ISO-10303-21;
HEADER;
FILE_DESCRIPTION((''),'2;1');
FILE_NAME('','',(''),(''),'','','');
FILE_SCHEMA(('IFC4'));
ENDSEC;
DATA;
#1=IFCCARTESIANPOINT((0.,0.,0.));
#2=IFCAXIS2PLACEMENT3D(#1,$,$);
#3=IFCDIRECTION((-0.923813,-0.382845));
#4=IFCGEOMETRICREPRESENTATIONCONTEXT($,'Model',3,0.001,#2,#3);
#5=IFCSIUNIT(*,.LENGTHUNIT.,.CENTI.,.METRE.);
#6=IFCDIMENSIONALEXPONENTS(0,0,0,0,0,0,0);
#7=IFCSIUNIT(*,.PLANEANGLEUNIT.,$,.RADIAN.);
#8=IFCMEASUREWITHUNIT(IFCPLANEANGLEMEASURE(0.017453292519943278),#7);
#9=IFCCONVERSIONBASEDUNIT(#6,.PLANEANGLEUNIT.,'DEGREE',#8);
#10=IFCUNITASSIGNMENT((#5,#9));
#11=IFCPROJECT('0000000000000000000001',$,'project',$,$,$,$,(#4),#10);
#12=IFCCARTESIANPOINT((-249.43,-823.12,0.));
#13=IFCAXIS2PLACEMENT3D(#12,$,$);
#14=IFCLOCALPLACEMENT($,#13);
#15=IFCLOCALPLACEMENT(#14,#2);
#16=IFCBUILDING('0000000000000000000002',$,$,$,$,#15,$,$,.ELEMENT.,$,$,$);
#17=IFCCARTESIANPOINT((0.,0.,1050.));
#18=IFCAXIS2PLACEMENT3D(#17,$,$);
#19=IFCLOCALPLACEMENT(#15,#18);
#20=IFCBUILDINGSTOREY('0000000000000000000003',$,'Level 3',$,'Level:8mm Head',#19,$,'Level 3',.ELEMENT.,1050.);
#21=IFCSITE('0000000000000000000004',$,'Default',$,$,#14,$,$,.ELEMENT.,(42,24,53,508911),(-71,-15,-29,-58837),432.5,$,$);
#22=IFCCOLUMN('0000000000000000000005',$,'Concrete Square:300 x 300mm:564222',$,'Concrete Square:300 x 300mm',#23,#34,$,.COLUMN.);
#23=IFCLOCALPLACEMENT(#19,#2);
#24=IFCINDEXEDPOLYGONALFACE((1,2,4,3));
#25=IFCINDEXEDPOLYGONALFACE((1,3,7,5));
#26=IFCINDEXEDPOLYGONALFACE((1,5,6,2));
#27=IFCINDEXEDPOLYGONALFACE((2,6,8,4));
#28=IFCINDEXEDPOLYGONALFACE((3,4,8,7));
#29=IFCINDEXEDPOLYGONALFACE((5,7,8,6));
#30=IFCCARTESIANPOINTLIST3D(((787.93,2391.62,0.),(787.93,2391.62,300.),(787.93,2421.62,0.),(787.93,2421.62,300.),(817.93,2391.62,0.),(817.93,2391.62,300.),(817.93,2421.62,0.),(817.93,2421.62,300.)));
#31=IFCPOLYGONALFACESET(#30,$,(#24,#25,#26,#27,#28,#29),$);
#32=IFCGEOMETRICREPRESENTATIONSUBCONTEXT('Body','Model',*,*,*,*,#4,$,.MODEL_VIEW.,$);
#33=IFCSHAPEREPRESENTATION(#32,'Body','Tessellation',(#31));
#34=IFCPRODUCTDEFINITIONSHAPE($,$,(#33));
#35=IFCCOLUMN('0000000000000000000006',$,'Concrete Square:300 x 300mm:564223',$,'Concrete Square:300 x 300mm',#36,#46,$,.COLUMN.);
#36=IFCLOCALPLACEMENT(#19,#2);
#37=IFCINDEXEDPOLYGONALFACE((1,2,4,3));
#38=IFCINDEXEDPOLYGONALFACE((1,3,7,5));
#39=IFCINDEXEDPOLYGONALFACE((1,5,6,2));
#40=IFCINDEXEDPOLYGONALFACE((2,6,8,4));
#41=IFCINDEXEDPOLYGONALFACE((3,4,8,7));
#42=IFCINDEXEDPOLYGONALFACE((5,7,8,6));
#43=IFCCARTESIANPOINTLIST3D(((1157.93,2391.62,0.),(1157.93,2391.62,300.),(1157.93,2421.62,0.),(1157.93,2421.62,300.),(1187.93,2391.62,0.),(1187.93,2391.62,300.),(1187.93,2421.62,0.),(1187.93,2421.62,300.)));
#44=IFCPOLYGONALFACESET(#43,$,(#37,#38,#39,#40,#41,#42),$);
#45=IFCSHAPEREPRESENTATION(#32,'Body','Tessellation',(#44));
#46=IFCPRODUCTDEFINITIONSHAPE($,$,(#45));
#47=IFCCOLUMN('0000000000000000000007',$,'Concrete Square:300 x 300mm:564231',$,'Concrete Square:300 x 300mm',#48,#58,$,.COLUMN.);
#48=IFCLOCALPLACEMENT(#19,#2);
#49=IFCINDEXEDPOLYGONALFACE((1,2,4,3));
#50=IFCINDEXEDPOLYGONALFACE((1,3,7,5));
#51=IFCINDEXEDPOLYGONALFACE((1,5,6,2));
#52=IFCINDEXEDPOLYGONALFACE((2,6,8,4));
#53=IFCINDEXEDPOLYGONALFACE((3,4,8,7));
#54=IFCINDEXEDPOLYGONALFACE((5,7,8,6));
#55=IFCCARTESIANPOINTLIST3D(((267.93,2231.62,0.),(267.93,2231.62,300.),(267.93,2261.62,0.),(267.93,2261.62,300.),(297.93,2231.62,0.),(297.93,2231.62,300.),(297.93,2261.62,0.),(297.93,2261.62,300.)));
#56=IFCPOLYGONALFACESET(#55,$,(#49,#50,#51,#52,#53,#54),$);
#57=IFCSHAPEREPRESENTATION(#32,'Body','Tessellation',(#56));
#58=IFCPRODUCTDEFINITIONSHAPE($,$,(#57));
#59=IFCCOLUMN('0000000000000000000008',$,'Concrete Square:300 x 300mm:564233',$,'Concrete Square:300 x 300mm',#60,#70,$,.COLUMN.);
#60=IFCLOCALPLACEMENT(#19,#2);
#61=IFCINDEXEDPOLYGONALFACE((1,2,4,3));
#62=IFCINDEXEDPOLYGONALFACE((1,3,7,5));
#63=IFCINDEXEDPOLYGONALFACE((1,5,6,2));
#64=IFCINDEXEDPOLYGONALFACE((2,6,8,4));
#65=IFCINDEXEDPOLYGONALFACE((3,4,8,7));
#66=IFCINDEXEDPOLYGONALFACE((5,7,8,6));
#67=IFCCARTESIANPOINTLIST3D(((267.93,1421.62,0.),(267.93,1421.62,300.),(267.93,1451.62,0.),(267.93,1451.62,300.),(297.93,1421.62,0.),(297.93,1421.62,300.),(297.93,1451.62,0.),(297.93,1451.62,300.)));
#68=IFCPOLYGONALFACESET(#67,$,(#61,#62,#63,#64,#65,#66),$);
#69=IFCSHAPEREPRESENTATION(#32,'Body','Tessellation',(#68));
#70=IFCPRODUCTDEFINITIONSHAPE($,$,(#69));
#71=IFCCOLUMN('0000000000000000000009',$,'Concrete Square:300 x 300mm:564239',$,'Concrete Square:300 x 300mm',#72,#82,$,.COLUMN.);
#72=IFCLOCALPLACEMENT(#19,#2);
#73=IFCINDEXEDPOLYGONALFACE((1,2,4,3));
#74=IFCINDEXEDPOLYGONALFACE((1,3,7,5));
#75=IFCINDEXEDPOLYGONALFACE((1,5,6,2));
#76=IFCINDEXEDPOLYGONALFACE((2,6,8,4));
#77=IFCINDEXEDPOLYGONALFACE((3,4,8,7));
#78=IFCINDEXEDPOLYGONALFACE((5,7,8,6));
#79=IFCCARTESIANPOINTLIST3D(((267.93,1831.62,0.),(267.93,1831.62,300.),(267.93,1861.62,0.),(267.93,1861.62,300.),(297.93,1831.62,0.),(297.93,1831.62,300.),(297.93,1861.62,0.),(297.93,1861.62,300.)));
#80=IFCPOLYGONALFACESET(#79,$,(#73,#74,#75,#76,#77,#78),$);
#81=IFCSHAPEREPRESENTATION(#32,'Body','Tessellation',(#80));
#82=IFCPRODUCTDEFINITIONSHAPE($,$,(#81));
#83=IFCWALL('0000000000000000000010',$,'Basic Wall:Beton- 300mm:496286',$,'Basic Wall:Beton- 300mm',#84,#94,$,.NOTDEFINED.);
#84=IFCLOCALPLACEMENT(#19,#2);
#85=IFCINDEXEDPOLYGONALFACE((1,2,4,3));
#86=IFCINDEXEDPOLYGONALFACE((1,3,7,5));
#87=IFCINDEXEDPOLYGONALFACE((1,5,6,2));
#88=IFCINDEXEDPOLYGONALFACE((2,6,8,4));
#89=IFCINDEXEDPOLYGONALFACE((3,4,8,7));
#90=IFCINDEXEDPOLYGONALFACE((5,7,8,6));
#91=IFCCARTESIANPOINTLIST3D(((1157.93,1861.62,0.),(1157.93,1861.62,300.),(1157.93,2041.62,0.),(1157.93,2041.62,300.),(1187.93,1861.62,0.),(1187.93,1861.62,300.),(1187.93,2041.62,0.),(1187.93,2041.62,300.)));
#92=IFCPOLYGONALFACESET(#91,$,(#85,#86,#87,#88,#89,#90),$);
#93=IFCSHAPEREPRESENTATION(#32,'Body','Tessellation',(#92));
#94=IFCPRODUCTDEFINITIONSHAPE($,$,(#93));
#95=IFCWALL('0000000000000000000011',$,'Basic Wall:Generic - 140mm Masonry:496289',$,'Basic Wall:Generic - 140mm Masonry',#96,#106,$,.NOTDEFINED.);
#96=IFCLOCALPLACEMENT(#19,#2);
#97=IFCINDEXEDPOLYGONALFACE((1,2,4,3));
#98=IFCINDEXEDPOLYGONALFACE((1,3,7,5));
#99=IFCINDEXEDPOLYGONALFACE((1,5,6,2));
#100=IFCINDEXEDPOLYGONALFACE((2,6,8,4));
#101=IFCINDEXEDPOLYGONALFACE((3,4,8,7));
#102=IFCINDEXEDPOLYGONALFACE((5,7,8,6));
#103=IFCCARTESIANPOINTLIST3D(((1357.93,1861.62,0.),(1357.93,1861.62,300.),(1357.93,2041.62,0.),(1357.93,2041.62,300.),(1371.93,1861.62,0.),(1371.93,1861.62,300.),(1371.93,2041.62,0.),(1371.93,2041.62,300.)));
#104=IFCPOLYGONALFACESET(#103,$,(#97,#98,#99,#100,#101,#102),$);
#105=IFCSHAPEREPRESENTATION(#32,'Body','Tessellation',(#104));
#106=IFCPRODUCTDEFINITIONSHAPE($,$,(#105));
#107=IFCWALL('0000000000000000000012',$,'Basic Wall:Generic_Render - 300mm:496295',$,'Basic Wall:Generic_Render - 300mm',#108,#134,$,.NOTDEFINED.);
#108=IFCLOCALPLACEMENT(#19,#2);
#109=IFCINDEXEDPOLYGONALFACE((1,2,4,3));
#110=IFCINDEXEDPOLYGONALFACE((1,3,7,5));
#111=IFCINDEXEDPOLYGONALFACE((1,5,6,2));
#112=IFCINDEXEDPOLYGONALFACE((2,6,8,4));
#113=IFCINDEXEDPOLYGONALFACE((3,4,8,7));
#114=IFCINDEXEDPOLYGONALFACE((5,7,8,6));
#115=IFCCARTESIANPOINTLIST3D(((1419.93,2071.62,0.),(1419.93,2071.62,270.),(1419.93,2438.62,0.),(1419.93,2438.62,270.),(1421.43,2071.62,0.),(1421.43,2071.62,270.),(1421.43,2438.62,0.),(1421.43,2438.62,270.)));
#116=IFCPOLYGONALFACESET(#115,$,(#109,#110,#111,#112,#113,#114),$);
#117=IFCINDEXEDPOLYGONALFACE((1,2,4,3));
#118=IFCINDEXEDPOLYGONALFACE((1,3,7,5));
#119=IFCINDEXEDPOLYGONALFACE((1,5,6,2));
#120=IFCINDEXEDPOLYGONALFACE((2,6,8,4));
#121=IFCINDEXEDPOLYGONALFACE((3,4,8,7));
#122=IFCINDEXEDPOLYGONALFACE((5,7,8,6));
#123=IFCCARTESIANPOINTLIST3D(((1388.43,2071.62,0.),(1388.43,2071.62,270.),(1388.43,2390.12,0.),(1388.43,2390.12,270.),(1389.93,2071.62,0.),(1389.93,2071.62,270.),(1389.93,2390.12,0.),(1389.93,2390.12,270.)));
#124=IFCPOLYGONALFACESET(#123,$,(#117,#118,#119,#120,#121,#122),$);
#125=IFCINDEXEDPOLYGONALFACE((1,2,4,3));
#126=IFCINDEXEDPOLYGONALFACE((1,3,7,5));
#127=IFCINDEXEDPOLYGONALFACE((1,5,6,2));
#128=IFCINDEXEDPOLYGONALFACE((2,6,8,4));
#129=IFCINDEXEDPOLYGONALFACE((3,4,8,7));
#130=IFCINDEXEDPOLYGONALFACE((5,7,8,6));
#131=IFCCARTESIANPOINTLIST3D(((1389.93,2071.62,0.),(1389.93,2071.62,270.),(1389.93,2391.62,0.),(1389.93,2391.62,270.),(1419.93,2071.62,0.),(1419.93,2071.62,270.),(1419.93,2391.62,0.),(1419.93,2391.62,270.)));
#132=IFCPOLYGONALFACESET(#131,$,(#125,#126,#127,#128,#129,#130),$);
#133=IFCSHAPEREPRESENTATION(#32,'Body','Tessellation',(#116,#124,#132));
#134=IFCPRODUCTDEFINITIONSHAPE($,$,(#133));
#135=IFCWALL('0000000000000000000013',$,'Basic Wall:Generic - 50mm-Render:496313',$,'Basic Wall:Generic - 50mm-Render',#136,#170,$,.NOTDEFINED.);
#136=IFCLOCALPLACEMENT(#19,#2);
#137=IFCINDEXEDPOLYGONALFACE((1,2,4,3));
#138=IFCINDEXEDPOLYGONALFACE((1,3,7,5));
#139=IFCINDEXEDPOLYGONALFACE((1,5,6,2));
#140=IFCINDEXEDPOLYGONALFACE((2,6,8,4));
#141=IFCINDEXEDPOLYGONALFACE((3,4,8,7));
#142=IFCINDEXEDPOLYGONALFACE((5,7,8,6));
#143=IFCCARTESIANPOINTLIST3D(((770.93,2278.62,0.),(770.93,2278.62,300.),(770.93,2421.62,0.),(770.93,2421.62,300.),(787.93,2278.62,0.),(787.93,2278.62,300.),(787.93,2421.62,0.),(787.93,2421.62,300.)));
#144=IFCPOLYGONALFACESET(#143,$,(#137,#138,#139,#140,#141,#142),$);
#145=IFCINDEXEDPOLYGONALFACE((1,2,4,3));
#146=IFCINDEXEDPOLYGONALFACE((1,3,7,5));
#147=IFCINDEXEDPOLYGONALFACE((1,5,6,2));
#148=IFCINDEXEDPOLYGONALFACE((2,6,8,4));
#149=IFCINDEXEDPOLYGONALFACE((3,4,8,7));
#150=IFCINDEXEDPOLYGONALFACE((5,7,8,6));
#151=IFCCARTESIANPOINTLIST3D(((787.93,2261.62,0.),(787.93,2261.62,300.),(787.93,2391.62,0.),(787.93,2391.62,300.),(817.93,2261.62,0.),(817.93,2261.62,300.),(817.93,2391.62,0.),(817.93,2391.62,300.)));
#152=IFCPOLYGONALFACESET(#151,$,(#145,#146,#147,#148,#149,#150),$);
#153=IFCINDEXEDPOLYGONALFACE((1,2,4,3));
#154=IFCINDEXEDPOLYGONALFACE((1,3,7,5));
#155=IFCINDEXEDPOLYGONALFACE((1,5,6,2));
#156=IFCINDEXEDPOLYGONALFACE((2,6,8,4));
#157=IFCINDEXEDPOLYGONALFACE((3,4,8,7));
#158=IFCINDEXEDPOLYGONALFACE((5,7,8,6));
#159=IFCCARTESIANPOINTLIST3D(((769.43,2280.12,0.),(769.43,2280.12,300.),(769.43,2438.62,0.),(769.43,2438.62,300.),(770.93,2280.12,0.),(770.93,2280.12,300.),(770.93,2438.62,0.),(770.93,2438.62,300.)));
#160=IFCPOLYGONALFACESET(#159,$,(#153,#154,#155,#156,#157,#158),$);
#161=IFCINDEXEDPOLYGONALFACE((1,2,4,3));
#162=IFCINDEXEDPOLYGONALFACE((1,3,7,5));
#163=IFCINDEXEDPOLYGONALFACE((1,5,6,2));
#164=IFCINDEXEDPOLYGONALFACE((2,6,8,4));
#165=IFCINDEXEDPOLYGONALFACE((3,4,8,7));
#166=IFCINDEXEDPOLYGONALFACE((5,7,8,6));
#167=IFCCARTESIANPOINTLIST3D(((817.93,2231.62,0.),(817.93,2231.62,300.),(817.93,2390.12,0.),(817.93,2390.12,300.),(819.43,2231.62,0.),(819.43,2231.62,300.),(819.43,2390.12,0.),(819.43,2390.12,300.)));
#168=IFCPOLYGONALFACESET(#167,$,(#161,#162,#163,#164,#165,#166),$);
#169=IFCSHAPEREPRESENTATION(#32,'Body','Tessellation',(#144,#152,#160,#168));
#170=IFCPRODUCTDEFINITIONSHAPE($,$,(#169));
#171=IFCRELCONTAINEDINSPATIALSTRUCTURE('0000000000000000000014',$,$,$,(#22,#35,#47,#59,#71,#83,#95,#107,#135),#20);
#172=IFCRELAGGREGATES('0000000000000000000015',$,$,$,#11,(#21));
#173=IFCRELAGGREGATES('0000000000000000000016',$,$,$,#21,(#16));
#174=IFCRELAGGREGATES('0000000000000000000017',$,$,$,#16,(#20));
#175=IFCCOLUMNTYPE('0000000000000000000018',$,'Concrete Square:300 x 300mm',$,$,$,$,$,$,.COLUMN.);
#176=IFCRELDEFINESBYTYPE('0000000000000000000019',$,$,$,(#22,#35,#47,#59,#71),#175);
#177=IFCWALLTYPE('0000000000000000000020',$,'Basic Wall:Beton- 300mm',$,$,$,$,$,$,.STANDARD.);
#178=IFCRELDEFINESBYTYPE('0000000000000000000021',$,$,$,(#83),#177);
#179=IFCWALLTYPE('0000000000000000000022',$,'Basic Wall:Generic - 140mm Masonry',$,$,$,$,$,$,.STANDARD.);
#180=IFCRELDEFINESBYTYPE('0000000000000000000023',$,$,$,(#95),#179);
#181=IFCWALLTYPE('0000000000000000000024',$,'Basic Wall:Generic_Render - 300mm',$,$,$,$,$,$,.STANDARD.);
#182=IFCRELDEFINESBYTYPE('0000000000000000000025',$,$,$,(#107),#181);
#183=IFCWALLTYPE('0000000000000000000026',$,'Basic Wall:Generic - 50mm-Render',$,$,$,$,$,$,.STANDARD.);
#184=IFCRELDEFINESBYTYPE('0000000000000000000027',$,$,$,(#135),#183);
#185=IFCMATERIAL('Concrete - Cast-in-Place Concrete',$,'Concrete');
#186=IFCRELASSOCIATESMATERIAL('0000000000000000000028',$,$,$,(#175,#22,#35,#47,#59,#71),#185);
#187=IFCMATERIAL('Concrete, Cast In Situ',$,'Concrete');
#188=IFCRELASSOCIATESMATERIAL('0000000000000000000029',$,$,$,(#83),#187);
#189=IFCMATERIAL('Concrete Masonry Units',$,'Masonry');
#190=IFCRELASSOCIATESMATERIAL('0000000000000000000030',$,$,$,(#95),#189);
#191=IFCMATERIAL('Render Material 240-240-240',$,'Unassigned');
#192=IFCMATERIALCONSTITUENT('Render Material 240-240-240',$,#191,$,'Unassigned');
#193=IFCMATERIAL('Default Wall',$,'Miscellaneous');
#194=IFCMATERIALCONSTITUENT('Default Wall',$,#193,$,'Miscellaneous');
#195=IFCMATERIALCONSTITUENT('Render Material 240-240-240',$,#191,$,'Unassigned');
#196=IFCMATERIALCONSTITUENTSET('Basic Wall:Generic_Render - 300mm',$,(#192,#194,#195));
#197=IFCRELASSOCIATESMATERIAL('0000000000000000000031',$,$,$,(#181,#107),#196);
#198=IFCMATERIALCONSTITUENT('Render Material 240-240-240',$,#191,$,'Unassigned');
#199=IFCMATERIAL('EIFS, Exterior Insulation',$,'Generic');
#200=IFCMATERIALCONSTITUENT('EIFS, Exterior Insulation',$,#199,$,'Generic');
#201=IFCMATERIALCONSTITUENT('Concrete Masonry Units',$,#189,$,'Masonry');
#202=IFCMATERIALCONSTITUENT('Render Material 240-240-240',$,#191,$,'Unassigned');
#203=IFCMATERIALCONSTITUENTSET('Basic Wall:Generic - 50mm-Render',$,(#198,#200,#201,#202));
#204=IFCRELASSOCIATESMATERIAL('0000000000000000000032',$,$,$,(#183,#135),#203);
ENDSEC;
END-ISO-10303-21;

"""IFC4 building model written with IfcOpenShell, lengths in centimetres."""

from ifc_helpers import new_model, entity, si_unit, converted_unit, direction, frame, origin, place, context, subcontext, project, spatial, indexed_curve, outline, extrude, source, transform, mapped, material, constituent, constituent_set, type_object, type_shapes, element, save


model = new_model("IFC4")

# Units and contexts
model_context = context("Model", 3, precision=0.001, world=origin(), true_north=direction((-0.923813, -0.382845)))
body_context = subcontext(model_context, "Body", "Model", "MODEL_VIEW")
ifc_project = project(units=[si_unit("LENGTHUNIT", "METRE", prefix="CENTI"), converted_unit("PLANEANGLEUNIT", "DEGREE", entity("IfcPlaneAngleMeasure", 0.017453292519943278), si_unit("PLANEANGLEUNIT", "RADIAN"), dimensions=[0, 0, 0, 0, 0, 0, 0])], contexts=[model_context])

# Site, building, storey
site_placement = place(None, frame((-249.43, -823.12, 0.0)))
site = spatial("IfcSite", under=ifc_project, at=site_placement, Name="Default", CompositionType="ELEMENT", RefLatitude=(42, 24, 53, 508911), RefLongitude=(-71, -15, -29, -58837), RefElevation=432.5)
building_placement = place(site_placement, origin())
building = spatial("IfcBuilding", under=site, at=building_placement, CompositionType="ELEMENT")
storey_placement = place(building_placement, frame((0.0, 0.0, 1050.0)))
storey = spatial("IfcBuildingStorey", under=building, at=storey_placement, Name="Level 3", ObjectType="Level:8mm Head", LongName="Level 3", CompositionType="ELEMENT", Elevation=1050.0)

# Columns
ifc_material_1 = material(Name="Concrete - Cast-in-Place Concrete", Category="Concrete")
column_type = type_object("IfcColumnType", Name="Concrete Square:300 x 300mm", PredefinedType="COLUMN", material=ifc_material_1)
shared_shape_1 = source(origin(), body_context, "Body", "SweptSolid", [
    extrude(outline(indexed_curve([(-15.0, -15.0), (15.0, -15.0), (15.0, 15.0), (-15.0, 15.0), (-15.0, -15.0)], self_intersect=False)), frame((0.0, 0.0, 1050.0), z_axis=(0.0, 0.0, 1.0), x_axis=(-1.0, 0.0, 0.0)), (0.0, 0.0, 1.0), 300.0),
])
type_shapes(column_type, [shared_shape_1])
for number, where, name in (
    (1, (802.93, 2406.62, -1050.0), "Concrete Square:300 x 300mm:564222"),
    (2, (1172.93, 2406.62, -1050.0), "Concrete Square:300 x 300mm:564223"),
    (3, (282.93, 2246.62, -1050.0), "Concrete Square:300 x 300mm:564231"),
    (4, (282.93, 1436.62, -1050.0), "Concrete Square:300 x 300mm:564233"),
    (5, (282.93, 1846.62, -1050.0), "Concrete Square:300 x 300mm:564239"),
):
    element("IfcColumn", number, at=place(storey_placement, frame(where)), inside=storey, type_object=column_type, material=ifc_material_1, Name=name, ObjectType="Concrete Square:300 x 300mm", PredefinedType="COLUMN", context=body_context, shape_type="MappedRepresentation", body=[
        mapped(shared_shape_1, transform((0.0, 0.0, 0.0), scale=1.0)),
    ])

# Walls
ifc_material_2 = material(Name="Concrete, Cast In Situ", Category="Concrete")
wall_type_1 = type_object("IfcWallType", Name="Basic Wall:Beton- 300mm", PredefinedType="STANDARD")
wall_1_placement = place(storey_placement, frame((1172.93, 2041.62, 0.0), z_axis=(0.0, 0.0, 1.0), x_axis=(0.0, -1.0, 0.0)))
element("IfcWall", 6, at=wall_1_placement, inside=storey, type_object=wall_type_1, material=ifc_material_2, Name="Basic Wall:Beton- 300mm:496286", ObjectType="Basic Wall:Beton- 300mm", PredefinedType="NOTDEFINED", context=body_context, shape_type="SweptSolid", body=[
    extrude(outline(indexed_curve([(180.0, 15.0), (0.0, 15.0), (0.0, -15.0), (180.0, -15.0), (180.0, 15.0)], self_intersect=False)), origin(), (0.0, 0.0, 1.0), 300.0),
])
ifc_material_3 = material(Name="Concrete Masonry Units", Category="Masonry")
wall_type_2 = type_object("IfcWallType", Name="Basic Wall:Generic - 140mm Masonry", PredefinedType="STANDARD")
wall_2_placement = place(storey_placement, frame((1364.93, 2041.62, 0.0), z_axis=(0.0, 0.0, 1.0), x_axis=(0.0, -1.0, 0.0)))
element("IfcWall", 7, at=wall_2_placement, inside=storey, type_object=wall_type_2, material=ifc_material_3, Name="Basic Wall:Generic - 140mm Masonry:496289", ObjectType="Basic Wall:Generic - 140mm Masonry", PredefinedType="NOTDEFINED", context=body_context, shape_type="SweptSolid", body=[
    extrude(outline(indexed_curve([(180.0, 7.0), (0.0, 7.0), (0.0, -7.0), (180.0, -7.0), (180.0, 7.0)], self_intersect=False)), origin(), (0.0, 0.0, 1.0), 300.0),
])
ifc_material_4 = material(Name="Render Material 240-240-240", Category="Unassigned")
ifc_constituent_1 = constituent(ifc_material_4, Name="Render Material 240-240-240", Category="Unassigned")
ifc_material_5 = material(Name="Default Wall", Category="Miscellaneous")
ifc_constituent_2 = constituent(ifc_material_5, Name="Default Wall", Category="Miscellaneous")
ifc_constituent_3 = constituent(ifc_material_4, Name="Render Material 240-240-240", Category="Unassigned")
ifc_constituent_set_1 = constituent_set(constituents=[ifc_constituent_1, ifc_constituent_2, ifc_constituent_3], Name="Basic Wall:Generic_Render - 300mm")
wall_type_3 = type_object("IfcWallType", Name="Basic Wall:Generic_Render - 300mm", PredefinedType="STANDARD", material=ifc_constituent_set_1)
wall_3_placement = place(storey_placement, frame((1404.93, 2071.62, 0.0), z_axis=(0.0, 0.0, 1.0), x_axis=(0.0, 1.0, 0.0)))
element("IfcWall", 8, at=wall_3_placement, inside=storey, type_object=wall_type_3, material=ifc_constituent_set_1, Name="Basic Wall:Generic_Render - 300mm:496295", ObjectType="Basic Wall:Generic_Render - 300mm", PredefinedType="NOTDEFINED", context=body_context, shape_type="SweptSolid", body=[
    extrude(outline(indexed_curve([(-0.75, -183.5), (0.75, -183.5), (0.75, 183.5), (-0.75, 183.5), (-0.75, -183.5)], self_intersect=False)), frame((183.5, -15.75, 0.0), z_axis=(0.0, 0.0, 1.0), x_axis=(0.0, 1.0, 0.0)), (0.0, 0.0, 1.0), 270.0),
    extrude(outline(indexed_curve([(-0.75, -159.25), (0.75, -159.25), (0.75, 159.25), (-0.75, 159.25), (-0.75, -159.25)], self_intersect=False)), frame((159.25, 15.75, 0.0), z_axis=(0.0, 0.0, 1.0), x_axis=(0.0, -1.0, 0.0)), (0.0, 0.0, 1.0), 270.0),
    extrude(outline(indexed_curve([(-160.0, -15.0), (160.0, -15.0), (160.0, 15.0), (-160.0, 15.0), (-160.0, -15.0)], self_intersect=False)), frame((160.0, 0.0, 0.0)), (0.0, 0.0, 1.0), 270.0),
])
ifc_constituent_4 = constituent(ifc_material_4, Name="Render Material 240-240-240", Category="Unassigned")
ifc_material_6 = material(Name="EIFS, Exterior Insulation", Category="Generic")
ifc_constituent_5 = constituent(ifc_material_6, Name="EIFS, Exterior Insulation", Category="Generic")
ifc_constituent_6 = constituent(ifc_material_3, Name="Concrete Masonry Units", Category="Masonry")
ifc_constituent_7 = constituent(ifc_material_4, Name="Render Material 240-240-240", Category="Unassigned")
ifc_constituent_set_2 = constituent_set(constituents=[ifc_constituent_4, ifc_constituent_5, ifc_constituent_6, ifc_constituent_7], Name="Basic Wall:Generic - 50mm-Render")
wall_type_4 = type_object("IfcWallType", Name="Basic Wall:Generic - 50mm-Render", PredefinedType="STANDARD", material=ifc_constituent_set_2)
wall_4_placement = place(storey_placement, frame((794.43, 2280.12, 0.0), z_axis=(0.0, 0.0, 1.0), x_axis=(0.0, 1.0, 0.0)))
element("IfcWall", 9, at=wall_4_placement, inside=storey, type_object=wall_type_4, material=ifc_constituent_set_2, Name="Basic Wall:Generic - 50mm-Render:496313", ObjectType="Basic Wall:Generic - 50mm-Render", PredefinedType="NOTDEFINED", context=body_context, shape_type="SweptSolid", body=[
    extrude(outline(indexed_curve([(-8.5, -71.5), (8.5, -71.5), (8.5, 71.5), (-8.5, 71.5), (-8.5, -71.5)], self_intersect=False)), frame((70.0, 15.0, 0.0), z_axis=(0.0, 0.0, 1.0), x_axis=(0.0, -1.0, 0.0)), (0.0, 0.0, 1.0), 300.0),
    extrude(outline(indexed_curve([(-15.0, -65.0), (15.0, -65.0), (15.0, 65.0), (-15.0, 65.0), (-15.0, -65.0)], self_intersect=False)), frame((46.5, -8.5, 0.0), z_axis=(0.0, 0.0, 1.0), x_axis=(0.0, 1.0, 0.0)), (0.0, 0.0, 1.0), 300.0),
    extrude(outline(indexed_curve([(-0.75, -79.25), (0.75, -79.25), (0.75, 79.25), (-0.75, 79.25), (-0.75, -79.25)], self_intersect=False)), frame((79.25, 24.25, 0.0), z_axis=(0.0, 0.0, 1.0), x_axis=(0.0, -1.0, 0.0)), (0.0, 0.0, 1.0), 300.0),
    extrude(outline(indexed_curve([(-0.75, -79.25), (0.75, -79.25), (0.75, 79.25), (-0.75, 79.25), (-0.75, -79.25)], self_intersect=False)), frame((30.75, -24.25, 0.0), z_axis=(0.0, 0.0, 1.0), x_axis=(0.0, -1.0, 0.0)), (0.0, 0.0, 1.0), 300.0),
])

save(model, "model.ifc")
